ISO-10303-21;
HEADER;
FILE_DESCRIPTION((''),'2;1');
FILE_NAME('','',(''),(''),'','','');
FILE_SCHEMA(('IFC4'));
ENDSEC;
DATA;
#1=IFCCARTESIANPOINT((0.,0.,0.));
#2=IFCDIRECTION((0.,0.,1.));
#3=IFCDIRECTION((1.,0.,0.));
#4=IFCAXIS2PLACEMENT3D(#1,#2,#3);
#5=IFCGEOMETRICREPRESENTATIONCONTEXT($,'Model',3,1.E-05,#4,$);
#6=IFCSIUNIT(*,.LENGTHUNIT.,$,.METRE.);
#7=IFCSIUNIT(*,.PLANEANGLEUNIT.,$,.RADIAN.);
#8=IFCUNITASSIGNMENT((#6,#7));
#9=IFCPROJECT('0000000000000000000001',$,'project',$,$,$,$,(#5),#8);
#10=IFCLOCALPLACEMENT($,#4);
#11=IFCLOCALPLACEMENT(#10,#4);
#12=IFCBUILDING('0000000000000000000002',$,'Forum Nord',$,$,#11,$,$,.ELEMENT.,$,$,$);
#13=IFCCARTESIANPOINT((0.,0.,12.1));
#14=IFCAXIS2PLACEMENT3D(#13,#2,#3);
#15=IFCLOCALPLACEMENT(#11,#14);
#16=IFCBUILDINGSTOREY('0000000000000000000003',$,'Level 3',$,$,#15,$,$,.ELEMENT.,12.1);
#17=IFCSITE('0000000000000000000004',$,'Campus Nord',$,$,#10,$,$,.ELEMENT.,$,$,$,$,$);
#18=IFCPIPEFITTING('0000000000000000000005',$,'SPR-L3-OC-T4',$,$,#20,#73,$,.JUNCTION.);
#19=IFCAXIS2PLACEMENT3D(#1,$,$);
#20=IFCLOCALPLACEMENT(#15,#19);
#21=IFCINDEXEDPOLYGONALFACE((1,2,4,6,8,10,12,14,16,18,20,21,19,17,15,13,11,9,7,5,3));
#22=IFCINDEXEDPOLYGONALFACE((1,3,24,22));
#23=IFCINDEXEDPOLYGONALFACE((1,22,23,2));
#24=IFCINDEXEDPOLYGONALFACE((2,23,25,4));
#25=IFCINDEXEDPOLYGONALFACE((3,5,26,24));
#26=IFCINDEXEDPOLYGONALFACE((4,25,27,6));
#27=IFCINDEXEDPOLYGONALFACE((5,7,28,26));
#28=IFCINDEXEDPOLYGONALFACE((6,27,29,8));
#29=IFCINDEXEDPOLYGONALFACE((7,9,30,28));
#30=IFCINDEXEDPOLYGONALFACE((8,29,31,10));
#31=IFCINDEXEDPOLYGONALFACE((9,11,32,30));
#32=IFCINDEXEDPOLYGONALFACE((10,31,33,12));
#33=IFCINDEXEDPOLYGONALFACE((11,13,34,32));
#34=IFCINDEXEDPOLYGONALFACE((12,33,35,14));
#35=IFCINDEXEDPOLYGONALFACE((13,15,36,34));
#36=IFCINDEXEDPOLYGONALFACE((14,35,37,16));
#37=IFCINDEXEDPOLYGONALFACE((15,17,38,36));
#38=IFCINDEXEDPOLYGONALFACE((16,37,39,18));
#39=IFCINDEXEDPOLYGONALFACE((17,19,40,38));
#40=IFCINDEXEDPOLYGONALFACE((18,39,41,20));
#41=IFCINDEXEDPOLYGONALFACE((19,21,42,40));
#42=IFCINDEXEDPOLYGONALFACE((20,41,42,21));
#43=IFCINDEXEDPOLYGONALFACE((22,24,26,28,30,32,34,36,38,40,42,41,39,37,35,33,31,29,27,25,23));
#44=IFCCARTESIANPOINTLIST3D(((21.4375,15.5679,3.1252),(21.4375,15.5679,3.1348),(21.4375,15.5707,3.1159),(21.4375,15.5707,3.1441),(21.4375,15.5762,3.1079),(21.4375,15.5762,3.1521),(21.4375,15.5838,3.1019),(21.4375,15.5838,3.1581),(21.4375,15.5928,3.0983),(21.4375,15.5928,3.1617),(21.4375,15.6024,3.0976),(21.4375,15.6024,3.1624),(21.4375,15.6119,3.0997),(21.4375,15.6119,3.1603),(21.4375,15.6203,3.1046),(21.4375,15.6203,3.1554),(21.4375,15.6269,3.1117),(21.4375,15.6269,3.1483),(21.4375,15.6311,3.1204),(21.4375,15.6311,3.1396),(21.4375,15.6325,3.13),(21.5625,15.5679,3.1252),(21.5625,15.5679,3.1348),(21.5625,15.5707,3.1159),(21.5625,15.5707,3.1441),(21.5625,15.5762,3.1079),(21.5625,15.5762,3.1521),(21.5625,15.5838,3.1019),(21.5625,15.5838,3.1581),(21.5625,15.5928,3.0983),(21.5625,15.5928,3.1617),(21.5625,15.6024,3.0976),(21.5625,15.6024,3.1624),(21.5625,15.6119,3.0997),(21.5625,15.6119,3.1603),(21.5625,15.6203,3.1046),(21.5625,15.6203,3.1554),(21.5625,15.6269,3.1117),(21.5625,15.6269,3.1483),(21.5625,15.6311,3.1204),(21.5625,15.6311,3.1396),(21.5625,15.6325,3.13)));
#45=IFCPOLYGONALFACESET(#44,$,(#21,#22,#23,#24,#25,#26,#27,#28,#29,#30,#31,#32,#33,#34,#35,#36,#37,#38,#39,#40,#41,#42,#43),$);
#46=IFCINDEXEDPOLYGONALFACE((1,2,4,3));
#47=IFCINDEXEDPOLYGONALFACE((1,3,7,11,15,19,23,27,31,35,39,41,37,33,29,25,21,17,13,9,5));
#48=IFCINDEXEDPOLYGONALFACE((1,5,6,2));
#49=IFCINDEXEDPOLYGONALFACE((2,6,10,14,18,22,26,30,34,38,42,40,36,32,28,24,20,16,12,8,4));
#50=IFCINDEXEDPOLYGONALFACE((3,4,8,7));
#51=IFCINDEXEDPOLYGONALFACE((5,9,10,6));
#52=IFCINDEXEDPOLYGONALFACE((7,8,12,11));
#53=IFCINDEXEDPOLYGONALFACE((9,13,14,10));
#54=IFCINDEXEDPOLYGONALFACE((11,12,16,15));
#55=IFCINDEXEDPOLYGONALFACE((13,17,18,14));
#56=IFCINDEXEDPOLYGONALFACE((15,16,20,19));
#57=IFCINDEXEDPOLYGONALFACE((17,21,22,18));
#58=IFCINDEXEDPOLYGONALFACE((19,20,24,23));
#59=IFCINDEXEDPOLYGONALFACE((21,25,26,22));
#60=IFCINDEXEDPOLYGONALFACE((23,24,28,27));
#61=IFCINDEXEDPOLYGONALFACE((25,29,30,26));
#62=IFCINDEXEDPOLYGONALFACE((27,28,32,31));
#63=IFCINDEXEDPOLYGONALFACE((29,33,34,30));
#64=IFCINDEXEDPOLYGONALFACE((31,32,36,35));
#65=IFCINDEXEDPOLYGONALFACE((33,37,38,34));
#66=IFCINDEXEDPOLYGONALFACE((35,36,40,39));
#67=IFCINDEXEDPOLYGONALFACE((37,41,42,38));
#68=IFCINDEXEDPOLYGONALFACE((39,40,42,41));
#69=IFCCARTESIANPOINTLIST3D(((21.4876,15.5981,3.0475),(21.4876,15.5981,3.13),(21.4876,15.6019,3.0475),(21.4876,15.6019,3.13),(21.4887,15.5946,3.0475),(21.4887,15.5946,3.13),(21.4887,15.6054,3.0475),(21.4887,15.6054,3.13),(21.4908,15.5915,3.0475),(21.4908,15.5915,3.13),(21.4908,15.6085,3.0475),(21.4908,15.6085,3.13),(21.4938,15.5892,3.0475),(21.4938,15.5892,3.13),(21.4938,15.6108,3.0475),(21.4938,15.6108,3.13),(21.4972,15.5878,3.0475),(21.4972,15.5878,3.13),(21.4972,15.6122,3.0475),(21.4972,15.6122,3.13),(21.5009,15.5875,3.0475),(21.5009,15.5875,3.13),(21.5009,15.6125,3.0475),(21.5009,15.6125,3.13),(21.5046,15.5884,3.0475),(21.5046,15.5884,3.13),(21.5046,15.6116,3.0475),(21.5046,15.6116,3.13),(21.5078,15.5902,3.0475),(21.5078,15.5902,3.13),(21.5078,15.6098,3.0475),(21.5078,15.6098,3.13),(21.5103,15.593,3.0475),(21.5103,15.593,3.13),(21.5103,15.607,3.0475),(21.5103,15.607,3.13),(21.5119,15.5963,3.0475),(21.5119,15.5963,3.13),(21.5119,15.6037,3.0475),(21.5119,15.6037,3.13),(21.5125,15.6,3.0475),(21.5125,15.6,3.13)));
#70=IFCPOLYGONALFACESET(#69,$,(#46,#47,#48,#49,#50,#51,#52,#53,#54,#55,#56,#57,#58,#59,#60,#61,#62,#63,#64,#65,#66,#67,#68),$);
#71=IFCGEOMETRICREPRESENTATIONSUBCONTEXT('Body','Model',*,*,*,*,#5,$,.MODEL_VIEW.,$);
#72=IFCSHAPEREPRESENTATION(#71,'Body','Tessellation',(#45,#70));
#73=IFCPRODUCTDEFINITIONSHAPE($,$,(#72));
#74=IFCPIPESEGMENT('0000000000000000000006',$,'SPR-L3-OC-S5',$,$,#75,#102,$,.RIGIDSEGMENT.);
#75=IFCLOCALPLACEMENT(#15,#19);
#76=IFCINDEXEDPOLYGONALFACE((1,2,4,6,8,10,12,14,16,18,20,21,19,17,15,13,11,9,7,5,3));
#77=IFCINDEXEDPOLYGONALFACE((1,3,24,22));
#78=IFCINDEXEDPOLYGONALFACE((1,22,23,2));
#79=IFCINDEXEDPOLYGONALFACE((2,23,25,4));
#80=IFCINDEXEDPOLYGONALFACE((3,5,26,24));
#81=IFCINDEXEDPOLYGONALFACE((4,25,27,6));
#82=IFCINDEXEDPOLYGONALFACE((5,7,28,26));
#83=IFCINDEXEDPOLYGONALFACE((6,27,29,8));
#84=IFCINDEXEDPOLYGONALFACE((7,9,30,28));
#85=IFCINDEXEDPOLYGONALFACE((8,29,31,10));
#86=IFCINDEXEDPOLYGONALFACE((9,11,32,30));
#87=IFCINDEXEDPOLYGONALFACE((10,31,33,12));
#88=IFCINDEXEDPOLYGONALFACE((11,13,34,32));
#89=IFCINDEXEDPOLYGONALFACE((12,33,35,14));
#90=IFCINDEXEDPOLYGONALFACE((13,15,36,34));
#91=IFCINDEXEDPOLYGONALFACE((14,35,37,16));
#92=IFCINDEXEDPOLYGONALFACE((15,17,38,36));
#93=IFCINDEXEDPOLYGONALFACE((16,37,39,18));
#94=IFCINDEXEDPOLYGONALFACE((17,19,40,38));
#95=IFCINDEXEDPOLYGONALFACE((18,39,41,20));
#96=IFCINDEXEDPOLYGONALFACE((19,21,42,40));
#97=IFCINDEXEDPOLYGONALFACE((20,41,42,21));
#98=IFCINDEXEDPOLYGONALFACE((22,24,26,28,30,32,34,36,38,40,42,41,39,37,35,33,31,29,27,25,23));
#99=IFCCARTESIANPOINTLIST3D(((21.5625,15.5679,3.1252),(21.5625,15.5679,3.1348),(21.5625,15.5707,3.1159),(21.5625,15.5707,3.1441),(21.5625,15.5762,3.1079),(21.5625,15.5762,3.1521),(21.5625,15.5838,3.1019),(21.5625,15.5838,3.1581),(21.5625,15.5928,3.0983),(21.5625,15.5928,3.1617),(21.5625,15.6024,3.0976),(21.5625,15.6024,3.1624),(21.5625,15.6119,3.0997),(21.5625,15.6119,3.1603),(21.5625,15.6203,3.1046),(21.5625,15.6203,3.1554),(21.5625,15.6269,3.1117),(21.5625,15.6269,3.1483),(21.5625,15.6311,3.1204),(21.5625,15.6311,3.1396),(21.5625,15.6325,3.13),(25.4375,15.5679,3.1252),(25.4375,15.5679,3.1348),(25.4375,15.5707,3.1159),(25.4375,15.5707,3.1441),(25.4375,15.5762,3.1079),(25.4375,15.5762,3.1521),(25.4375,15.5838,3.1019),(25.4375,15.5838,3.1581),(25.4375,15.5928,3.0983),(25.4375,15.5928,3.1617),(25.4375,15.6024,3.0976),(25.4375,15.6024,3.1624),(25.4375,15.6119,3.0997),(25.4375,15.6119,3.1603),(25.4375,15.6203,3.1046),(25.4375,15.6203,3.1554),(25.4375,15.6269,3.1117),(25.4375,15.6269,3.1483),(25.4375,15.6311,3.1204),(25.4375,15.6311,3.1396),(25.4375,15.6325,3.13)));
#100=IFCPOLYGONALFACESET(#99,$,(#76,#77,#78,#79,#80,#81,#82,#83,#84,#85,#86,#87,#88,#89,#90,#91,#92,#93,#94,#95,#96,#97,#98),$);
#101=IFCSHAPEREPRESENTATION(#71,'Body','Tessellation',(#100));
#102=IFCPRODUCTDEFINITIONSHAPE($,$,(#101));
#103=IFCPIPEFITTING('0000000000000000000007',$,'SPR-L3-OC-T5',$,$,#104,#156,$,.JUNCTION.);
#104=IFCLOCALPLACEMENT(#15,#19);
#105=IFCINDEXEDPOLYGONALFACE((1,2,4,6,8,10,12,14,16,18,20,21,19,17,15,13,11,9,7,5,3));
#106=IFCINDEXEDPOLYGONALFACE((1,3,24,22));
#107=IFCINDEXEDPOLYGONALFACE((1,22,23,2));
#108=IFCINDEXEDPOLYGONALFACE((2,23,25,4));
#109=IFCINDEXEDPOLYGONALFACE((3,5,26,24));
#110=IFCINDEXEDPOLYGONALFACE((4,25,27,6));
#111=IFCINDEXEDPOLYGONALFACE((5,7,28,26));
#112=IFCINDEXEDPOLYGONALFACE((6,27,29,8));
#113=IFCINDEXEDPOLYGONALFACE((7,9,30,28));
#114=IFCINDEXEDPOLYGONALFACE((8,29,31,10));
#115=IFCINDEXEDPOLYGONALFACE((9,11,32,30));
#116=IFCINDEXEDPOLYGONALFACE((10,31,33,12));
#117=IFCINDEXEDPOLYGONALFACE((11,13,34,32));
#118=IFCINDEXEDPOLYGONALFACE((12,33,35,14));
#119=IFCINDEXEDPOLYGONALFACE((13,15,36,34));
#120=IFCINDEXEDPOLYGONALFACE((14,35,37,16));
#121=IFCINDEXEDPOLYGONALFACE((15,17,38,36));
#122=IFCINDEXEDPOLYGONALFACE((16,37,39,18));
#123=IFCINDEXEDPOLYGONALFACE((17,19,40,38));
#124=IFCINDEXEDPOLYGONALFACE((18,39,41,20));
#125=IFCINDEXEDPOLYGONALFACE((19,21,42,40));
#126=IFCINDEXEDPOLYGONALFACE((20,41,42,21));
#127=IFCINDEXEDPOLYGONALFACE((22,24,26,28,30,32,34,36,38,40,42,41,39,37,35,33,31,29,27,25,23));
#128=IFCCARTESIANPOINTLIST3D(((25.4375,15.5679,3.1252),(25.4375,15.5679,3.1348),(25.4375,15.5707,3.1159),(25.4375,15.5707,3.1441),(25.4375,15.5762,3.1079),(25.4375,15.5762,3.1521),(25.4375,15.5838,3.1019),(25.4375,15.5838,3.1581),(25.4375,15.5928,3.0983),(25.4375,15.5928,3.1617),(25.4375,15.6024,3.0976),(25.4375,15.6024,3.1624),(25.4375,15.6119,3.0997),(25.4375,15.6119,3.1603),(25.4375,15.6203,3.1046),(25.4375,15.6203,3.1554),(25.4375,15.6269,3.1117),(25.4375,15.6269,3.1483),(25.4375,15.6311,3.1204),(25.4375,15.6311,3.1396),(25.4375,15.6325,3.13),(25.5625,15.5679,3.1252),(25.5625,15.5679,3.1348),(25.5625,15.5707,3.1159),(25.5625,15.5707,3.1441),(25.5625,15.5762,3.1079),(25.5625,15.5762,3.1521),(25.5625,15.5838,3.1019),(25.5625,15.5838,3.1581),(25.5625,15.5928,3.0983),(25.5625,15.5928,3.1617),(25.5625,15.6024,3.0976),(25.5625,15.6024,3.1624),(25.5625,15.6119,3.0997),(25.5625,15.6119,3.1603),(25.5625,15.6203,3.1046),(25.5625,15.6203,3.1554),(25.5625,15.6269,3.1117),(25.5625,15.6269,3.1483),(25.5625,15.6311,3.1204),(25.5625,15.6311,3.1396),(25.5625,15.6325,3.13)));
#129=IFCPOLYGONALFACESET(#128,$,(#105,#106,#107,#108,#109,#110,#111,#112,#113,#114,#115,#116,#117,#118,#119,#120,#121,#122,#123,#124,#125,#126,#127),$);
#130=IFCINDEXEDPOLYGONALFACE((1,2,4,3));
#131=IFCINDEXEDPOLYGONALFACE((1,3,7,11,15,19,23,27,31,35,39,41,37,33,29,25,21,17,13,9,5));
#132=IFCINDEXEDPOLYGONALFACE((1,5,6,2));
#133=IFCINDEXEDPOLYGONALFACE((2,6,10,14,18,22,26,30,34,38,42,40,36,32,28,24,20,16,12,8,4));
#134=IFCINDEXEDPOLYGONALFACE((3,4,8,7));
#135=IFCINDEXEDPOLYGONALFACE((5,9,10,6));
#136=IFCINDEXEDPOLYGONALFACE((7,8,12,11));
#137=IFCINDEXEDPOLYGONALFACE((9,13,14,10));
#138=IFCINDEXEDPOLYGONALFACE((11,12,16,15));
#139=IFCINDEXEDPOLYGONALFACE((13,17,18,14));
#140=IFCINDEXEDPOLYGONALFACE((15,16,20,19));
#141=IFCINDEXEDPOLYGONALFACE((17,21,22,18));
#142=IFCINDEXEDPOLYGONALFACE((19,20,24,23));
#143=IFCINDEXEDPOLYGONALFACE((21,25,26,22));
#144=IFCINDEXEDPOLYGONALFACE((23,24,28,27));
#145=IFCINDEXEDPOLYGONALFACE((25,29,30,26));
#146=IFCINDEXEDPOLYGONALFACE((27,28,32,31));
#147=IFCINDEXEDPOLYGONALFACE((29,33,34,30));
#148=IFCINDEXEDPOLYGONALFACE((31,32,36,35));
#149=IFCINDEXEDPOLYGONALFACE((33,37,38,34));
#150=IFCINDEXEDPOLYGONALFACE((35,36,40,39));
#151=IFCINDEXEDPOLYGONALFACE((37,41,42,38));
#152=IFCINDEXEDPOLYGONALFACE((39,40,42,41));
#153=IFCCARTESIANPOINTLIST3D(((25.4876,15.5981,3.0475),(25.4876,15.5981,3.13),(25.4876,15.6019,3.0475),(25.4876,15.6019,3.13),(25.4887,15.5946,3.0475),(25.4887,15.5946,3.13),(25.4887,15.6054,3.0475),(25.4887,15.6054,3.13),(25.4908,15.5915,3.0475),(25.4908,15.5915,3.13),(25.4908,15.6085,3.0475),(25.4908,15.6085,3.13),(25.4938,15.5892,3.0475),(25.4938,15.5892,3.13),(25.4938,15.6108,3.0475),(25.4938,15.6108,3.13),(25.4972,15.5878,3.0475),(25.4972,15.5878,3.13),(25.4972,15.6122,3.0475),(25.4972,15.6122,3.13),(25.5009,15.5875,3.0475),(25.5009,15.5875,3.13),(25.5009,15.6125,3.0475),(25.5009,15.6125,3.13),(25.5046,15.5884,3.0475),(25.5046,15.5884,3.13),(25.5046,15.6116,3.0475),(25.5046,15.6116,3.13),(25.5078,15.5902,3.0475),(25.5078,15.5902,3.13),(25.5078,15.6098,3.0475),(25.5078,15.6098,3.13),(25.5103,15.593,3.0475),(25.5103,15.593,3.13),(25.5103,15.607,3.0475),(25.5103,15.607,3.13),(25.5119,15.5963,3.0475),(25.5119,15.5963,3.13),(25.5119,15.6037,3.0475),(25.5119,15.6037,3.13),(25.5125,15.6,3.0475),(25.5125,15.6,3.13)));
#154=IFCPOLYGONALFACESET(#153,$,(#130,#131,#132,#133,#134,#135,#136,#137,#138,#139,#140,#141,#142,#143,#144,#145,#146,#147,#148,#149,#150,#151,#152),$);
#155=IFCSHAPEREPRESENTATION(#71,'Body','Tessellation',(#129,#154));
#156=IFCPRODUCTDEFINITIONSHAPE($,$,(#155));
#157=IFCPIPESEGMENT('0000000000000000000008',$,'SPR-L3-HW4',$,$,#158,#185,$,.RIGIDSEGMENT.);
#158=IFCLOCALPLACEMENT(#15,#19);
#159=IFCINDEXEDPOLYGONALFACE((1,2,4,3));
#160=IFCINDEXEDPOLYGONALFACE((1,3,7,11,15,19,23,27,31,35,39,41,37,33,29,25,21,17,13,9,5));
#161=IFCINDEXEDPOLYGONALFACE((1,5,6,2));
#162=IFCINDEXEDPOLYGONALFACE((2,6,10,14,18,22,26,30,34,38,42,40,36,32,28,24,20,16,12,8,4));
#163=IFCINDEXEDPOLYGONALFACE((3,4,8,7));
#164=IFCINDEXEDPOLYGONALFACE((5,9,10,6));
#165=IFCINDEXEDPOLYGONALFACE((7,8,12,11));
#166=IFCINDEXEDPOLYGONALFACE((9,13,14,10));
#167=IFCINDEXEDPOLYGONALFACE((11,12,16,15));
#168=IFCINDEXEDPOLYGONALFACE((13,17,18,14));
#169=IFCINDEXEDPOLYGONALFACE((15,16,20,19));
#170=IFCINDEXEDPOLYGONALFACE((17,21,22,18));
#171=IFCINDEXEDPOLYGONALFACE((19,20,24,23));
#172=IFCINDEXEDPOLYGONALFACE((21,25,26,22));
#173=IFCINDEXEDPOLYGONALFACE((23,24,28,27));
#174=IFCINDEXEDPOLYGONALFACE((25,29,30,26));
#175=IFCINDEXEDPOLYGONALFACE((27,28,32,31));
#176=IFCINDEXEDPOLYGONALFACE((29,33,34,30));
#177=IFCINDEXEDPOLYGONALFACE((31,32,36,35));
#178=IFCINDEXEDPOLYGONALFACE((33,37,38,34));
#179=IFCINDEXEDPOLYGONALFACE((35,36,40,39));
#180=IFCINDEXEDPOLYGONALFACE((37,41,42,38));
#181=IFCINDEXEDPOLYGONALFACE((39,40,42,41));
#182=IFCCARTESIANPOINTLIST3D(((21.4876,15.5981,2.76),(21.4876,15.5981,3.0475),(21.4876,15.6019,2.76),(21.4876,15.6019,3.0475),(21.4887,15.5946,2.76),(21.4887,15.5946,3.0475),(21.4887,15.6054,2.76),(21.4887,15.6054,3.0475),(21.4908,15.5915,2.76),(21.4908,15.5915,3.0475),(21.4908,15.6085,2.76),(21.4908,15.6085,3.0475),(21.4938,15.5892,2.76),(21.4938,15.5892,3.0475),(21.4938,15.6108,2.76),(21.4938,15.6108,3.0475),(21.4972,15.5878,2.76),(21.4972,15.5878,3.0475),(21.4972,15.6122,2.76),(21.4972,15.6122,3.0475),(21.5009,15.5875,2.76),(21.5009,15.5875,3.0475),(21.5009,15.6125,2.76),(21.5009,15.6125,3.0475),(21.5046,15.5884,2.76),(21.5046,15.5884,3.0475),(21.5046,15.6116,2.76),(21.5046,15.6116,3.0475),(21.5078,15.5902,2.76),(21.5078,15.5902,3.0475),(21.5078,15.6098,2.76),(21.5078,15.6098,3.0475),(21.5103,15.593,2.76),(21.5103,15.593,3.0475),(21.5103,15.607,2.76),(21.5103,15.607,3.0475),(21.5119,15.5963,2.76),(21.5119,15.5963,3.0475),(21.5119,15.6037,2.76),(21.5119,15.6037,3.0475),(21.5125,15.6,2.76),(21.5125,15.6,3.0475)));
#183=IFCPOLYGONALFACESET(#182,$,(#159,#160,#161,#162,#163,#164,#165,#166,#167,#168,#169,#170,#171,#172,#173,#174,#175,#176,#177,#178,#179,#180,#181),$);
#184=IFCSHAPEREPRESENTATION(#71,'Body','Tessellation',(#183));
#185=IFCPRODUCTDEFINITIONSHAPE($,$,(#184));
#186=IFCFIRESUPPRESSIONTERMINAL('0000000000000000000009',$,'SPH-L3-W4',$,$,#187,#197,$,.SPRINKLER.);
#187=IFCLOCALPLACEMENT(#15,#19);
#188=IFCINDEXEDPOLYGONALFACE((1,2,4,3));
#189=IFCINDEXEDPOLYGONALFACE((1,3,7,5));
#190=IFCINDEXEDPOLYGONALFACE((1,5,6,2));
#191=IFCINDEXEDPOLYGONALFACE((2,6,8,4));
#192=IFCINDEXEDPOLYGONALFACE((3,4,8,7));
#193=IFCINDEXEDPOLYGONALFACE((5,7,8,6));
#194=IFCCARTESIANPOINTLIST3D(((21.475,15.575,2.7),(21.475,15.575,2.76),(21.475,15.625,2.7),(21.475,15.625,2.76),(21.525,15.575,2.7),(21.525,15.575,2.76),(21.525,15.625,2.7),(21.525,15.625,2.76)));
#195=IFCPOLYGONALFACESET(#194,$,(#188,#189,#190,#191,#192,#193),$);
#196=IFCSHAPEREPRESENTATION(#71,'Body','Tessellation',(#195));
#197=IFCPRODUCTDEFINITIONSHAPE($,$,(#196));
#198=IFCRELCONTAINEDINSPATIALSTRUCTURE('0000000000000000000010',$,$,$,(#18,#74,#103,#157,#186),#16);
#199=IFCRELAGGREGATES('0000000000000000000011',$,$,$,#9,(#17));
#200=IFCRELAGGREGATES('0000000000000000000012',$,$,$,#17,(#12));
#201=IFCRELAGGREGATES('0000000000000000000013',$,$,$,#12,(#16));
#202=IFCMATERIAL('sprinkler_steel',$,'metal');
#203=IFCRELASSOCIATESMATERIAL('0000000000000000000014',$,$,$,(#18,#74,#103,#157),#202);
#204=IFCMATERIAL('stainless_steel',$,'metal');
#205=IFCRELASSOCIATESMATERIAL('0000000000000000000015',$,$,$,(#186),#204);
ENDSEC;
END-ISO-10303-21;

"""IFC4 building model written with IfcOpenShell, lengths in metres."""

from ifc_helpers import new_model, si_unit, frame, origin_with_axes, origin_2d_with_axis, place, context, subcontext, project, spatial, rectangle, circle, extrude, material, element, save


model = new_model("IFC4")

# Units and contexts
model_context = context("Model", 3, precision=1e-05, world=origin_with_axes())
body_context = subcontext(model_context, "Body", "Model", "MODEL_VIEW")
ifc_project = project(units=[si_unit("LENGTHUNIT", "METRE"), si_unit("PLANEANGLEUNIT", "RADIAN")], contexts=[model_context])

# Site, building, storey
site_placement = place(None, origin_with_axes())
site = spatial("IfcSite", under=ifc_project, at=site_placement, Name="Campus Nord", CompositionType="ELEMENT")
building_placement = place(site_placement, origin_with_axes())
building = spatial("IfcBuilding", under=site, at=building_placement, Name="Forum Nord", CompositionType="ELEMENT")
storey_placement = place(building_placement, frame((0.0, 0.0, 12.1), z_axis=(0.0, 0.0, 1.0), x_axis=(1.0, 0.0, 0.0)))
storey = spatial("IfcBuildingStorey", under=building, at=storey_placement, Name="Level 3", CompositionType="ELEMENT", Elevation=12.1)

# Pipe fitting
ifc_material_1 = material(Name="sprinkler_steel", Category="metal")
pipe_fitting_1_placement = place(storey_placement, frame((21.4375, 15.6, 3.13), z_axis=(1.0, 0.0, 0.0), x_axis=(0.0, 1.0, 0.0)))
element("IfcPipeFitting", 1, at=pipe_fitting_1_placement, inside=storey, material=ifc_material_1, Name="SPR-L3-OC-T4", PredefinedType="JUNCTION", context=body_context, shape_type="SweptSolid", body=[
    extrude(circle(Radius=0.0325, at=origin_2d_with_axis()), origin_with_axes(), (0.0, 0.0, 1.0), 0.125),
    extrude(circle(Radius=0.0125, at=origin_2d_with_axis()), frame((0.0, 0.0, 0.0625), z_axis=(0.0, -1.0, 0.0), x_axis=(0.0, 0.0, 1.0)), (0.0, 0.0, 1.0), 0.0825),
])

# Pipe segment
pipe_segment_1_placement = place(storey_placement, frame((21.5625, 15.6, 3.13), z_axis=(1.0, 0.0, 0.0), x_axis=(0.0, 1.0, 0.0)))
element("IfcPipeSegment", 2, at=pipe_segment_1_placement, inside=storey, material=ifc_material_1, Name="SPR-L3-OC-S5", PredefinedType="RIGIDSEGMENT", context=body_context, shape_type="SweptSolid", body=[
    extrude(circle(Radius=0.0325, at=origin_2d_with_axis()), origin_with_axes(), (0.0, 0.0, 1.0), 3.875),
])

# Pipe fitting
pipe_fitting_2_placement = place(storey_placement, frame((25.4375, 15.6, 3.13), z_axis=(1.0, 0.0, 0.0), x_axis=(0.0, 1.0, 0.0)))
element("IfcPipeFitting", 3, at=pipe_fitting_2_placement, inside=storey, material=ifc_material_1, Name="SPR-L3-OC-T5", PredefinedType="JUNCTION", context=body_context, shape_type="SweptSolid", body=[
    extrude(circle(Radius=0.0325, at=origin_2d_with_axis()), origin_with_axes(), (0.0, 0.0, 1.0), 0.125),
    extrude(circle(Radius=0.0125, at=origin_2d_with_axis()), frame((0.0, 0.0, 0.0625), z_axis=(0.0, -1.0, 0.0), x_axis=(0.0, 0.0, 1.0)), (0.0, 0.0, 1.0), 0.0825),
])

# Pipe segment
pipe_segment_2_placement = place(storey_placement, frame((21.5, 15.6, 3.0475), z_axis=(0.0, 0.0, -1.0), x_axis=(1.0, 0.0, 0.0)))
element("IfcPipeSegment", 4, at=pipe_segment_2_placement, inside=storey, material=ifc_material_1, Name="SPR-L3-HW4", PredefinedType="RIGIDSEGMENT", context=body_context, shape_type="SweptSolid", body=[
    extrude(circle(Radius=0.0125, at=origin_2d_with_axis()), origin_with_axes(), (0.0, 0.0, 1.0), 0.2875),
])

# Fire suppression terminal
ifc_material_2 = material(Name="stainless_steel", Category="metal")
fire_suppression_terminal_placement = place(storey_placement, frame((21.5, 15.6, 2.7), z_axis=(0.0, 0.0, 1.0), x_axis=(1.0, 0.0, 0.0)))
element("IfcFireSuppressionTerminal", 5, at=fire_suppression_terminal_placement, inside=storey, material=ifc_material_2, Name="SPH-L3-W4", PredefinedType="SPRINKLER", context=body_context, shape_type="SweptSolid", body=[
    extrude(rectangle(XDim=0.05, YDim=0.05, at=origin_2d_with_axis()), origin_with_axes(), (0.0, 0.0, 1.0), 0.06),
])

save(model, "model.ifc")
